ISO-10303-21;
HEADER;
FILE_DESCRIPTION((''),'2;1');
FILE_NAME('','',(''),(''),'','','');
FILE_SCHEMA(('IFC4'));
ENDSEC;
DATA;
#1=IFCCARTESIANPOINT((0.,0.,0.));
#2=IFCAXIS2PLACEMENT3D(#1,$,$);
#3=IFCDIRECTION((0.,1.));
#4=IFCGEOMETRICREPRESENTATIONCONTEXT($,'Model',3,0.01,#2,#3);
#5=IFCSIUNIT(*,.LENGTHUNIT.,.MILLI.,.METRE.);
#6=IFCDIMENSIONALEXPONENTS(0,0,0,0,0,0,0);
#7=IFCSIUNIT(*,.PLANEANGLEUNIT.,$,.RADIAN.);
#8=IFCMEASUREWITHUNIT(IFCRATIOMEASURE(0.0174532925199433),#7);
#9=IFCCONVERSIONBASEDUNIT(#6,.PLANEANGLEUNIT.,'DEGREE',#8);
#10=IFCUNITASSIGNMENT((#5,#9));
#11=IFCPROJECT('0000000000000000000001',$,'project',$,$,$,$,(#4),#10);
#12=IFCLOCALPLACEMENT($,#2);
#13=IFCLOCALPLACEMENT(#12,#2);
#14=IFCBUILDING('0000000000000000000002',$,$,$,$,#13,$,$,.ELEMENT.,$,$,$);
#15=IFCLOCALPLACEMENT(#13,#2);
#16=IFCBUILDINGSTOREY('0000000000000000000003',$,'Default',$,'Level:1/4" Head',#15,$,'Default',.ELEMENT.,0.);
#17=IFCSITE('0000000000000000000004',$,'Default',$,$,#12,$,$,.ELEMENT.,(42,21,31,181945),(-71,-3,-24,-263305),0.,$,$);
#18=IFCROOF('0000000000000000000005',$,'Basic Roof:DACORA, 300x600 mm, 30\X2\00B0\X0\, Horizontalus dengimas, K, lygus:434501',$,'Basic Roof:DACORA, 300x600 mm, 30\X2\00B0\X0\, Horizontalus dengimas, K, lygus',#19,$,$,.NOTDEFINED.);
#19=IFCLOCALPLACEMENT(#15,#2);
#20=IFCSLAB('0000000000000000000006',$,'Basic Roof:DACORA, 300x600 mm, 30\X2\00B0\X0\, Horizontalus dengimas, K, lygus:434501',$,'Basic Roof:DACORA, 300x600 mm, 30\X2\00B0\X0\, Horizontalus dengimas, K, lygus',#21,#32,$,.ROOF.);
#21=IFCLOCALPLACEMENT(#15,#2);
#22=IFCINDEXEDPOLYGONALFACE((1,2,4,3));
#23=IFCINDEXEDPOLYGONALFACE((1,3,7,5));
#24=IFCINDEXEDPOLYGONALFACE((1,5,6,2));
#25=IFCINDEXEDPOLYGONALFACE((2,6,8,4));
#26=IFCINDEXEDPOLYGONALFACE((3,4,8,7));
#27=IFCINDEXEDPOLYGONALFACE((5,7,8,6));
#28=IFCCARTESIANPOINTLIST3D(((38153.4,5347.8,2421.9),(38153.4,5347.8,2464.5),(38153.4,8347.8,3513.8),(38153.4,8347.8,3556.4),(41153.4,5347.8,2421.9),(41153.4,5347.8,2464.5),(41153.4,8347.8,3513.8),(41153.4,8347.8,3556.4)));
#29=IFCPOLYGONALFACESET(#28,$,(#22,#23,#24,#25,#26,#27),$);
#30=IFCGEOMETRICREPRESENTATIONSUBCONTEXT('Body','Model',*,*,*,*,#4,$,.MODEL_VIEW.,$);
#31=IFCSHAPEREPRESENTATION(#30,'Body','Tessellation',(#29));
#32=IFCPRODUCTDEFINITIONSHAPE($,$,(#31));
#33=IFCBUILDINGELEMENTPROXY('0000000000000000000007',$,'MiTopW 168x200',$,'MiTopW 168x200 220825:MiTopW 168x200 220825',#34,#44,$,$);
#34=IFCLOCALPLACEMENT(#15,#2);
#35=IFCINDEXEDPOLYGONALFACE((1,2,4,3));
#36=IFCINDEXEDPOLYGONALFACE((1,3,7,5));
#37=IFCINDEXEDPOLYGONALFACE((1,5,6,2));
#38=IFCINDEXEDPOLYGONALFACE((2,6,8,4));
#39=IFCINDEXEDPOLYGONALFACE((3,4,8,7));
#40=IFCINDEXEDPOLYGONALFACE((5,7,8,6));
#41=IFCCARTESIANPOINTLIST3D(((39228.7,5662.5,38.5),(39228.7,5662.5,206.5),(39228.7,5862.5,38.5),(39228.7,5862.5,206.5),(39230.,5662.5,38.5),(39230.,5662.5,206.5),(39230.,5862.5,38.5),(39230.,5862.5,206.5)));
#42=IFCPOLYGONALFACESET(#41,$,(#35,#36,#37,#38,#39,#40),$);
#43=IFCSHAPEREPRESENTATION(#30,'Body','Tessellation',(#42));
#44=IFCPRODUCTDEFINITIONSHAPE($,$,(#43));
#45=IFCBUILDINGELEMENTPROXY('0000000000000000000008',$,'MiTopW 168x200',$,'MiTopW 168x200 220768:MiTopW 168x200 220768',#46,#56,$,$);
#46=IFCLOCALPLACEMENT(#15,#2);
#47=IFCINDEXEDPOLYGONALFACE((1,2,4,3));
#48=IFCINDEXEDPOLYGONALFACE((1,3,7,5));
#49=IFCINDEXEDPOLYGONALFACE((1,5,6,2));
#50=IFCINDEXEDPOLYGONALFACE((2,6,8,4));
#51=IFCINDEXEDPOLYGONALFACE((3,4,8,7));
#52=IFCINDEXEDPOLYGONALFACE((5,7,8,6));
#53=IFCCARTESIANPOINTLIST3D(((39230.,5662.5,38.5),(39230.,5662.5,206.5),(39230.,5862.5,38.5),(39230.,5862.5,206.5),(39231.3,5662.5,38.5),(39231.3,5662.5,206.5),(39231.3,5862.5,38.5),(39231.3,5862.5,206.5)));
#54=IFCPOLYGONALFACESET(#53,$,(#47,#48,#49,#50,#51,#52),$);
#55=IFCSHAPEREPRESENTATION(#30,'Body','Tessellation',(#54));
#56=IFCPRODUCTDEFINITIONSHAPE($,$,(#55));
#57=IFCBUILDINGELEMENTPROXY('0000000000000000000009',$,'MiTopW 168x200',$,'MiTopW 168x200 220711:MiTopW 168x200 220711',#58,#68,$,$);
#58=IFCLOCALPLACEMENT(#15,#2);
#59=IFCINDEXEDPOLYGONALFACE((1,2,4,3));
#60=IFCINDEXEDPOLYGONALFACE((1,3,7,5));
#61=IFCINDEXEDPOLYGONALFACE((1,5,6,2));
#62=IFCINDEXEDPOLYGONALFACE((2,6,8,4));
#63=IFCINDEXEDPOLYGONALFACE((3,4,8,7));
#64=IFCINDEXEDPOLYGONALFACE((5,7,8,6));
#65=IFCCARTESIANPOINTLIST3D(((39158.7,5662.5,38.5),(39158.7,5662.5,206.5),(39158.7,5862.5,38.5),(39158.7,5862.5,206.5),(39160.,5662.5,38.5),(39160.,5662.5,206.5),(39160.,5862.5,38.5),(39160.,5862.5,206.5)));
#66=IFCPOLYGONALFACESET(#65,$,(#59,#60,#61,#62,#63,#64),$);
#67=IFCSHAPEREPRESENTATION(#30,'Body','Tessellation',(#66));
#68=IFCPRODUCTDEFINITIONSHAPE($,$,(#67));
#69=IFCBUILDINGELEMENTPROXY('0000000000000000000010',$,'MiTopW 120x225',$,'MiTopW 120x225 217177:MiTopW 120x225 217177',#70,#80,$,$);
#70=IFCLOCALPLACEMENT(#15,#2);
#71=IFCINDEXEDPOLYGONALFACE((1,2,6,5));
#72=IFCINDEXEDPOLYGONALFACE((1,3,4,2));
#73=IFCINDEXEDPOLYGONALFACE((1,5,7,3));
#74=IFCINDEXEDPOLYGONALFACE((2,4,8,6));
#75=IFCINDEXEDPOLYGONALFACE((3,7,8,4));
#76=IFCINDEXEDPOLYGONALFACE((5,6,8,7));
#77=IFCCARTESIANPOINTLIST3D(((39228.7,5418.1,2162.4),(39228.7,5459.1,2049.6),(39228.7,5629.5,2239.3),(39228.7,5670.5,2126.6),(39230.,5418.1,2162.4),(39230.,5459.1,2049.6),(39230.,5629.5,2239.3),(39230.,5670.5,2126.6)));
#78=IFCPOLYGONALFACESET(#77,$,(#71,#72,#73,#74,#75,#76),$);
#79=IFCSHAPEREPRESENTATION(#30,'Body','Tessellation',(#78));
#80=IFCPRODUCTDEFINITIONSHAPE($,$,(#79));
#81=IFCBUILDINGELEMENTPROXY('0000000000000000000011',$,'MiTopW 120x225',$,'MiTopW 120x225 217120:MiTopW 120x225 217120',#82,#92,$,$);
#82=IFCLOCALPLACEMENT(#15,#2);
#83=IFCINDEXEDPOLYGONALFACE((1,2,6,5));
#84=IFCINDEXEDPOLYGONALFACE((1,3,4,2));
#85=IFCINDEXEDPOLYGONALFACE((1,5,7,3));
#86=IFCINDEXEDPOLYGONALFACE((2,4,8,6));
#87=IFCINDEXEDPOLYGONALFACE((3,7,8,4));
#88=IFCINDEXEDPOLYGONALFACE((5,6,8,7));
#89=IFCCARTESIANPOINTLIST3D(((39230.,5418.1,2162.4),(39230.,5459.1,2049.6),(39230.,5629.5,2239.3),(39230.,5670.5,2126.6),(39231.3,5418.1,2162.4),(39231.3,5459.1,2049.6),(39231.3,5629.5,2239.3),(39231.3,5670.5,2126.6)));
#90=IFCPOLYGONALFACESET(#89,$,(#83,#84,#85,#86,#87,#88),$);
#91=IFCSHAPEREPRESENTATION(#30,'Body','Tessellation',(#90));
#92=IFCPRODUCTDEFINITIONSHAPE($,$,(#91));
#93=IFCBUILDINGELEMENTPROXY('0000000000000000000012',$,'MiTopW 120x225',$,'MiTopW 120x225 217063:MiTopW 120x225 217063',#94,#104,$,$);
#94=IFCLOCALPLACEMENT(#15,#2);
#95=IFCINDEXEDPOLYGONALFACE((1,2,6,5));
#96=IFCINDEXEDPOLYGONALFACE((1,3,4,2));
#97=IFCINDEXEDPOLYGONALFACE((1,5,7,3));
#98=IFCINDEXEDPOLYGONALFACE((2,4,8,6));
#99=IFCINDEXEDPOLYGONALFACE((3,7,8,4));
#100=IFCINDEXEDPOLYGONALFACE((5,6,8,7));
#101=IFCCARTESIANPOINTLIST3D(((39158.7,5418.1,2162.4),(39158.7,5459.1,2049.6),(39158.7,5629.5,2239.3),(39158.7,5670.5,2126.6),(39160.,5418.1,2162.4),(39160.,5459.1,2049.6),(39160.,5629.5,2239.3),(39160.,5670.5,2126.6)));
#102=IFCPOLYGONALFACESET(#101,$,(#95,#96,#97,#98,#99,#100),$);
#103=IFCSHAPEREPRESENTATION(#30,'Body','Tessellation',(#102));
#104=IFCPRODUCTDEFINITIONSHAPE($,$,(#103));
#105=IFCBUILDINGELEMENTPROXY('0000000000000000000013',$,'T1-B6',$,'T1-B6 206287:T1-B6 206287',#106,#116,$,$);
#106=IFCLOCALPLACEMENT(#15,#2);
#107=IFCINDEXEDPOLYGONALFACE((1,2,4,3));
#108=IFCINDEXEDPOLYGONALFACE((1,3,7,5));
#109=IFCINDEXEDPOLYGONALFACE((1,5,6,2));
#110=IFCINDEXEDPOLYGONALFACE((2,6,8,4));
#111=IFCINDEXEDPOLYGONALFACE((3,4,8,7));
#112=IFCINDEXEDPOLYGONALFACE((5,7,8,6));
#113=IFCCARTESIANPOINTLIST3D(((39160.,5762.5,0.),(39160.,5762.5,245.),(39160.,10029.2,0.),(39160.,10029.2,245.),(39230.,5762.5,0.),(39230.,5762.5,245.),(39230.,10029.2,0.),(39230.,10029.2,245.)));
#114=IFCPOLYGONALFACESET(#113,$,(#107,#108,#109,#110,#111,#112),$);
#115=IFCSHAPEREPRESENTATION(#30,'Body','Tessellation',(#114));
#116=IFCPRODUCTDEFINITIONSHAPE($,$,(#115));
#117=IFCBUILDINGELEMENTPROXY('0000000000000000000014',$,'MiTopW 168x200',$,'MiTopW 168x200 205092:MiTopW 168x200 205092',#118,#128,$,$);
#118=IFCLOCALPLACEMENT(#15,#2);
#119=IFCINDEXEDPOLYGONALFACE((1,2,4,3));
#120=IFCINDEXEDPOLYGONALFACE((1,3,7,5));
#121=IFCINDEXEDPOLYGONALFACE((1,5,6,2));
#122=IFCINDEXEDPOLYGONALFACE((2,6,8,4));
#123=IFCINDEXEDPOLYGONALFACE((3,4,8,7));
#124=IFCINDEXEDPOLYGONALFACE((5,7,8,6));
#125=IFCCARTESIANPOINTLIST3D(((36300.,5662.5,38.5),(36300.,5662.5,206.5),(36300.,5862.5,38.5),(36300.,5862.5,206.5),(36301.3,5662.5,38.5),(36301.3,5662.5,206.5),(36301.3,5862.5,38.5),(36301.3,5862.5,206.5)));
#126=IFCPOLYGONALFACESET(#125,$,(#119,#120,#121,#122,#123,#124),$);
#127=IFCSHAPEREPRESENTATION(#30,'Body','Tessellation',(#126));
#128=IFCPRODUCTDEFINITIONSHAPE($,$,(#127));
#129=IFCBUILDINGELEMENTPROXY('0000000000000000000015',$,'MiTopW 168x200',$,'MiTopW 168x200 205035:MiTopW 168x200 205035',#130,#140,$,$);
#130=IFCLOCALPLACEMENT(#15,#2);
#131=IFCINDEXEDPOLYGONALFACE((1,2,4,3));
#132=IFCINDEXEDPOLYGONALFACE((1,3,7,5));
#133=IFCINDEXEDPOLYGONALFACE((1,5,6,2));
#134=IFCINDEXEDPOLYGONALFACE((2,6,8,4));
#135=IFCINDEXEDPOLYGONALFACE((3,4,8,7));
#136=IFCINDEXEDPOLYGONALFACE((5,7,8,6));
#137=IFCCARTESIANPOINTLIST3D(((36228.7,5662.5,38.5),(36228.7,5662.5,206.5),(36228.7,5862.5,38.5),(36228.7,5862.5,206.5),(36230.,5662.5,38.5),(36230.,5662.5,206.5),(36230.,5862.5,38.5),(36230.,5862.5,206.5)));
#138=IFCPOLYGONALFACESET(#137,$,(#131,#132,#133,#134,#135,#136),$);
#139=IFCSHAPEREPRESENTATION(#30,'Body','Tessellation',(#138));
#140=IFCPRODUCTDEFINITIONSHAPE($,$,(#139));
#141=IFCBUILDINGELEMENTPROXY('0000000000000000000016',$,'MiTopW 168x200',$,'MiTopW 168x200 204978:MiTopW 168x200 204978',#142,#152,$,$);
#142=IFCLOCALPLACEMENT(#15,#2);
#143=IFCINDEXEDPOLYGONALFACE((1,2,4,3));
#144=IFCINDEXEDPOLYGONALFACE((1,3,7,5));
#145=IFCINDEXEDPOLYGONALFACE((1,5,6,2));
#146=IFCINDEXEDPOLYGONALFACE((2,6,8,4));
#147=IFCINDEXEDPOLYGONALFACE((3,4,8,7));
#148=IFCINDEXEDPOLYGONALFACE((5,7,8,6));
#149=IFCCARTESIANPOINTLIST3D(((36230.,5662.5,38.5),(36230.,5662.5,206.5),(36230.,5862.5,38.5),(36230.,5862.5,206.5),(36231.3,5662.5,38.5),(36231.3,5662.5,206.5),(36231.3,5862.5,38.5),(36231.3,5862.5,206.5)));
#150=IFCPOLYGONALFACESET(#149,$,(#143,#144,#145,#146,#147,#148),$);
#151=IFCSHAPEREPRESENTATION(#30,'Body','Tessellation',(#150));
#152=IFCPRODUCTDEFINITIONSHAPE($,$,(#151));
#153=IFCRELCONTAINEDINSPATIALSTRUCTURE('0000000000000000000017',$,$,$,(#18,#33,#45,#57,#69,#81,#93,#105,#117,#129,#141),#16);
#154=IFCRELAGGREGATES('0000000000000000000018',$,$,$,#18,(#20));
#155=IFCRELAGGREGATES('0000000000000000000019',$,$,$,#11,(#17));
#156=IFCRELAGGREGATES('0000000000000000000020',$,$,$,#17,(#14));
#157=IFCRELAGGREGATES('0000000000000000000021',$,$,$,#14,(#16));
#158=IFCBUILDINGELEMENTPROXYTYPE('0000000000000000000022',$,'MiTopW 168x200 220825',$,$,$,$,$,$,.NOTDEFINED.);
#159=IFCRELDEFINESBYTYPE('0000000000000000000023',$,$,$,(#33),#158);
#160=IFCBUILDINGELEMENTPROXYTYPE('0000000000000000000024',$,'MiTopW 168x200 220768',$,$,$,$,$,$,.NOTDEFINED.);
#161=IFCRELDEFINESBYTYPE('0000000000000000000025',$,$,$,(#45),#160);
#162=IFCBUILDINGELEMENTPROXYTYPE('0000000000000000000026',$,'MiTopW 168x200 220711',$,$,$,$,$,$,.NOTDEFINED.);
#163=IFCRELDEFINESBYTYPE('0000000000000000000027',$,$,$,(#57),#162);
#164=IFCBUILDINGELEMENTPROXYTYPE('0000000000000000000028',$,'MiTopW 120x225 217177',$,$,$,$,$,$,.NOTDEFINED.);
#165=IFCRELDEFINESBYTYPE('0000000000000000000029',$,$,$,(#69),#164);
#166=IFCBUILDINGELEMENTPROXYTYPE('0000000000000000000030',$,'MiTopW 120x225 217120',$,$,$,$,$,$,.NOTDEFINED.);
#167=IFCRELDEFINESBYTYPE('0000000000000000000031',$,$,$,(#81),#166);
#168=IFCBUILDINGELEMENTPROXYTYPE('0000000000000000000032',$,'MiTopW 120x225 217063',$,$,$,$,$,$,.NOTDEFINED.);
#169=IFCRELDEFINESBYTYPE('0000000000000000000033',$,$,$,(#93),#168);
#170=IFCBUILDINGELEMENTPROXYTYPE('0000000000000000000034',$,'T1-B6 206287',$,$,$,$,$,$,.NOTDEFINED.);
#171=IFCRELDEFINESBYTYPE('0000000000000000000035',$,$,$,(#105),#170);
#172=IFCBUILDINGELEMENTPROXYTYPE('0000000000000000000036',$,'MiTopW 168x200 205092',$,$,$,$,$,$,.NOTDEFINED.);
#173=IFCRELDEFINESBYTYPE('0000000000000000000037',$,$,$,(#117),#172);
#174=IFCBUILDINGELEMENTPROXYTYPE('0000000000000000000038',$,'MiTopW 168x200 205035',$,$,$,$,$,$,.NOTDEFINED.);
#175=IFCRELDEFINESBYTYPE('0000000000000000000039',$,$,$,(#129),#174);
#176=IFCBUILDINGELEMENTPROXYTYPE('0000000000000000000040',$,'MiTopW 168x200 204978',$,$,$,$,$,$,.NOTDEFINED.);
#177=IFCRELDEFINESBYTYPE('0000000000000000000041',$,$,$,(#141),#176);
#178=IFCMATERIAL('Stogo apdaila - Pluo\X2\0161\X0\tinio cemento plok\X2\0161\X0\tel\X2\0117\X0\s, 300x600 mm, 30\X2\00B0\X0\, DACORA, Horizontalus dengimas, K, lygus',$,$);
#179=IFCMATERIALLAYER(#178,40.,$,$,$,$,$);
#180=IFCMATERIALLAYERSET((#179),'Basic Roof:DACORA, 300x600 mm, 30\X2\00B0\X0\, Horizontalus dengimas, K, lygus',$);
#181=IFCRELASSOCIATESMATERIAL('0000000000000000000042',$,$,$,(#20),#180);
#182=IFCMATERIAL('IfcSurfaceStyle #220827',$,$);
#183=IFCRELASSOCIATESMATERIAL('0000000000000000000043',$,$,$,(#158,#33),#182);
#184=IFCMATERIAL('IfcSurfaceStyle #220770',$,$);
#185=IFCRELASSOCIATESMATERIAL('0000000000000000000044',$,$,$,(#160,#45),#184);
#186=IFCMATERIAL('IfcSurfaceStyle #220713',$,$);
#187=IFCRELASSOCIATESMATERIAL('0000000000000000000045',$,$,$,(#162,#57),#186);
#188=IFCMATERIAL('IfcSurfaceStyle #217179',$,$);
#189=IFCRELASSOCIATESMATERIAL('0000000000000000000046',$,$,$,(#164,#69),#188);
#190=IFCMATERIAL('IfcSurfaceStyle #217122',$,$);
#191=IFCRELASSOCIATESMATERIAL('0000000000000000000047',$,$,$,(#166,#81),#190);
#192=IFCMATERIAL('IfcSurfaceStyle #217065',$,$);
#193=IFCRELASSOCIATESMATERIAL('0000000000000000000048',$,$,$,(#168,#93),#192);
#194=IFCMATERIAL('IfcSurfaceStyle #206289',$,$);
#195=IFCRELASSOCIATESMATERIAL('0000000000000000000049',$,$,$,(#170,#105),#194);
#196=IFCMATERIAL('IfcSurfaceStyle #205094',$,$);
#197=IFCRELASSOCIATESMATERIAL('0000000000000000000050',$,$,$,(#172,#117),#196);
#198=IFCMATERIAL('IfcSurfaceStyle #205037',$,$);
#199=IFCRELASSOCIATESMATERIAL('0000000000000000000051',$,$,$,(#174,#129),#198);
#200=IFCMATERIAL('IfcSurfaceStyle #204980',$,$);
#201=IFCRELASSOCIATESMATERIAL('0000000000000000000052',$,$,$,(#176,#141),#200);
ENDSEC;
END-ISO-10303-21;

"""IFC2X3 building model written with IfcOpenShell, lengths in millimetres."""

from ifc_helpers import new_model, entity, si_unit, converted_unit, direction, frame, frame_2d, origin, origin_2d_with_axis, place, context, subcontext, project, spatial, polyline, rectangle, outline, extrude, source, transform, mapped, material, layer, layer_set, type_object, type_shapes, element, aggregate, save


model = new_model("IFC2X3")

# Units and contexts
model_context = context("Model", 3, precision=0.01, world=origin(), true_north=direction((0.0, 1.0)))
body_context = subcontext(model_context, "Body", "Model", "MODEL_VIEW")
ifc_project = project(units=[si_unit("LENGTHUNIT", "METRE", prefix="MILLI"), converted_unit("PLANEANGLEUNIT", "DEGREE", entity("IfcRatioMeasure", 0.0174532925199433), si_unit("PLANEANGLEUNIT", "RADIAN"), dimensions=[0, 0, 0, 0, 0, 0, 0])], contexts=[model_context])

# Site, building, storey
site_placement = place(None, origin())
site = spatial("IfcSite", under=ifc_project, at=site_placement, Name="Default", CompositionType="ELEMENT", RefLatitude=(42, 21, 31, 181945), RefLongitude=(-71, -3, -24, -263305), RefElevation=0.0)
building_placement = place(site_placement, origin())
building = spatial("IfcBuilding", under=site, at=building_placement, CompositionType="ELEMENT")
storey_placement = place(building_placement, origin())
storey = spatial("IfcBuildingStorey", under=building, at=storey_placement, Name="Default", ObjectType="Level:1/4\" Head", LongName="Default", CompositionType="ELEMENT", Elevation=0.0)

# Roof, slab
roof_placement = place(storey_placement, frame((38153.4, 5347.8, 2421.9)))
roof = element("IfcRoof", 1, at=roof_placement, inside=storey, Name="Basic Roof:DACORA, 300x600 mm, 30°, Horizontalus dengimas, K, lygus:434501", ObjectType="Basic Roof:DACORA, 300x600 mm, 30°, Horizontalus dengimas, K, lygus", ShapeType="NOTDEFINED")
ifc_material_1 = material(Name="Stogo apdaila - Pluoštinio cemento plokštelės, 300x600 mm, 30°, DACORA, Horizontalus dengimas, K, lygus")
ifc_layer = layer(ifc_material_1, 40.0)
ifc_layer_set = layer_set([ifc_layer], Name="Basic Roof:DACORA, 300x600 mm, 30°, Horizontalus dengimas, K, lygus")
slab_placement = place(roof_placement, origin())
slab = element("IfcSlab", 2, at=slab_placement, material=ifc_layer_set, Name="Basic Roof:DACORA, 300x600 mm, 30°, Horizontalus dengimas, K, lygus:434501", ObjectType="Basic Roof:DACORA, 300x600 mm, 30°, Horizontalus dengimas, K, lygus", PredefinedType="ROOF", context=body_context, shape_type="SweptSolid", body=[
    extrude(rectangle(XDim=3192.5, YDim=3000.0, at=frame_2d((0.0, 0.0), x_axis=(0.0, -1.0))), frame((1500.0, 1500.0, 546.0), z_axis=(0.0, -0.34202, 0.939693), x_axis=(1.0, 0.0, 0.0)), (0.0, 0.34202, 0.939693), 42.6),
])
aggregate(roof, [slab])

# Building element proxies
ifc_material_2 = material(Name="IfcSurfaceStyle #220827")
building_element_proxy_type_1 = type_object("IfcBuildingElementProxyType", Name="MiTopW 168x200 220825", PredefinedType="NOTDEFINED", material=ifc_material_2)
shared_shape_1 = source(origin(), body_context, "Body", "SweptSolid", [
    extrude(rectangle(XDim=200.0, YDim=168.0, at=origin_2d_with_axis()), frame((100.0, 84.0, 0.0), z_axis=(0.0, 0.0, 1.0), x_axis=(-1.0, 0.0, 0.0)), (0.0, 0.0, 1.0), 1.3),
])
type_shapes(building_element_proxy_type_1, [shared_shape_1])
proxy_1_placement = place(building_placement, frame((39230.0, 5662.5, 206.5), z_axis=(-1.0, 0.0, 0.0), x_axis=(0.0, 1.0, 0.0)))
element("IfcBuildingElementProxy", 3, at=proxy_1_placement, inside=storey, type_object=building_element_proxy_type_1, material=ifc_material_2, Name="MiTopW 168x200", ObjectType="MiTopW 168x200 220825:MiTopW 168x200 220825", context=body_context, shape_type="MappedRepresentation", body=[
    mapped(shared_shape_1, transform((0.0, 0.0, 0.0), scale=1.0)),
])
ifc_material_3 = material(Name="IfcSurfaceStyle #220770")
building_element_proxy_type_2 = type_object("IfcBuildingElementProxyType", Name="MiTopW 168x200 220768", PredefinedType="NOTDEFINED", material=ifc_material_3)
shared_shape_2 = source(origin(), body_context, "Body", "SweptSolid", [
    extrude(rectangle(XDim=200.0, YDim=168.0, at=origin_2d_with_axis()), frame((100.0, 84.0, 0.0), z_axis=(0.0, 0.0, 1.0), x_axis=(-1.0, 0.0, 0.0)), (0.0, 0.0, 1.0), 1.3),
])
type_shapes(building_element_proxy_type_2, [shared_shape_2])
proxy_2_placement = place(building_placement, frame((39231.3, 5662.5, 206.5), z_axis=(-1.0, 0.0, 0.0), x_axis=(0.0, 1.0, 0.0)))
element("IfcBuildingElementProxy", 4, at=proxy_2_placement, inside=storey, type_object=building_element_proxy_type_2, material=ifc_material_3, Name="MiTopW 168x200", ObjectType="MiTopW 168x200 220768:MiTopW 168x200 220768", context=body_context, shape_type="MappedRepresentation", body=[
    mapped(shared_shape_2, transform((0.0, 0.0, 0.0), scale=1.0)),
])
ifc_material_4 = material(Name="IfcSurfaceStyle #220713")
building_element_proxy_type_3 = type_object("IfcBuildingElementProxyType", Name="MiTopW 168x200 220711", PredefinedType="NOTDEFINED", material=ifc_material_4)
shared_shape_3 = source(origin(), body_context, "Body", "SweptSolid", [
    extrude(rectangle(XDim=200.0, YDim=168.0, at=origin_2d_with_axis()), frame((100.0, 84.0, 0.0), z_axis=(0.0, 0.0, 1.0), x_axis=(-1.0, 0.0, 0.0)), (0.0, 0.0, 1.0), 1.3),
])
type_shapes(building_element_proxy_type_3, [shared_shape_3])
proxy_3_placement = place(building_placement, frame((39160.0, 5662.5, 206.5), z_axis=(-1.0, 0.0, 0.0), x_axis=(0.0, 1.0, 0.0)))
element("IfcBuildingElementProxy", 5, at=proxy_3_placement, inside=storey, type_object=building_element_proxy_type_3, material=ifc_material_4, Name="MiTopW 168x200", ObjectType="MiTopW 168x200 220711:MiTopW 168x200 220711", context=body_context, shape_type="MappedRepresentation", body=[
    mapped(shared_shape_3, transform((0.0, 0.0, 0.0), scale=1.0)),
])
ifc_material_5 = material(Name="IfcSurfaceStyle #217179")
building_element_proxy_type_4 = type_object("IfcBuildingElementProxyType", Name="MiTopW 120x225 217177", PredefinedType="NOTDEFINED", material=ifc_material_5)
shared_shape_4 = source(origin(), body_context, "Body", "SweptSolid", [
    extrude(outline(polyline([(-112.5, -60.0), (112.5, -60.0), (112.5, 60.0), (-112.5, 60.0), (-112.5, -60.0)])), frame((112.5, 60.0, 0.0), z_axis=(0.0, 0.0, 1.0), x_axis=(-1.0, 0.0, 0.0)), (0.0, 0.0, 1.0), 1.3),
])
type_shapes(building_element_proxy_type_4, [shared_shape_4])
proxy_4_placement = place(building_placement, frame((39230.0, 5418.1, 2162.4), z_axis=(-1.0, 0.0, 0.0), x_axis=(0.0, 0.939693, 0.34202)))
element("IfcBuildingElementProxy", 6, at=proxy_4_placement, inside=storey, type_object=building_element_proxy_type_4, material=ifc_material_5, Name="MiTopW 120x225", ObjectType="MiTopW 120x225 217177:MiTopW 120x225 217177", context=body_context, shape_type="MappedRepresentation", body=[
    mapped(shared_shape_4, transform((0.0, 0.0, 0.0), scale=1.0)),
])
ifc_material_6 = material(Name="IfcSurfaceStyle #217122")
building_element_proxy_type_5 = type_object("IfcBuildingElementProxyType", Name="MiTopW 120x225 217120", PredefinedType="NOTDEFINED", material=ifc_material_6)
shared_shape_5 = source(origin(), body_context, "Body", "SweptSolid", [
    extrude(outline(polyline([(-112.5, -60.0), (112.5, -60.0), (112.5, 60.0), (-112.5, 60.0), (-112.5, -60.0)])), frame((112.5, 60.0, 0.0), z_axis=(0.0, 0.0, 1.0), x_axis=(-1.0, 0.0, 0.0)), (0.0, 0.0, 1.0), 1.3),
])
type_shapes(building_element_proxy_type_5, [shared_shape_5])
proxy_5_placement = place(building_placement, frame((39231.3, 5418.1, 2162.4), z_axis=(-1.0, 0.0, 0.0), x_axis=(0.0, 0.939693, 0.34202)))
element("IfcBuildingElementProxy", 7, at=proxy_5_placement, inside=storey, type_object=building_element_proxy_type_5, material=ifc_material_6, Name="MiTopW 120x225", ObjectType="MiTopW 120x225 217120:MiTopW 120x225 217120", context=body_context, shape_type="MappedRepresentation", body=[
    mapped(shared_shape_5, transform((0.0, 0.0, 0.0), scale=1.0)),
])
ifc_material_7 = material(Name="IfcSurfaceStyle #217065")
building_element_proxy_type_6 = type_object("IfcBuildingElementProxyType", Name="MiTopW 120x225 217063", PredefinedType="NOTDEFINED", material=ifc_material_7)
shared_shape_6 = source(origin(), body_context, "Body", "SweptSolid", [
    extrude(outline(polyline([(-112.5, -60.0), (112.5, -60.0), (112.5, 60.0), (-112.5, 60.0), (-112.5, -60.0)])), frame((112.5, 60.0, 0.0), z_axis=(0.0, 0.0, 1.0), x_axis=(-1.0, 0.0, 0.0)), (0.0, 0.0, 1.0), 1.3),
])
type_shapes(building_element_proxy_type_6, [shared_shape_6])
proxy_6_placement = place(building_placement, frame((39160.0, 5418.1, 2162.4), z_axis=(-1.0, 0.0, 0.0), x_axis=(0.0, 0.939693, 0.34202)))
element("IfcBuildingElementProxy", 8, at=proxy_6_placement, inside=storey, type_object=building_element_proxy_type_6, material=ifc_material_7, Name="MiTopW 120x225", ObjectType="MiTopW 120x225 217063:MiTopW 120x225 217063", context=body_context, shape_type="MappedRepresentation", body=[
    mapped(shared_shape_6, transform((0.0, 0.0, 0.0), scale=1.0)),
])
ifc_material_8 = material(Name="IfcSurfaceStyle #206289")
building_element_proxy_type_7 = type_object("IfcBuildingElementProxyType", Name="T1-B6 206287", PredefinedType="NOTDEFINED", material=ifc_material_8)
shared_shape_7 = source(origin(), body_context, "Body", "SweptSolid", [
    extrude(rectangle(XDim=4266.8, YDim=245.0, at=origin_2d_with_axis()), frame((2133.4, 122.5, 0.0), z_axis=(0.0, 0.0, 1.0), x_axis=(-1.0, 0.0, 0.0)), (0.0, 0.0, 1.0), 70.0),
])
type_shapes(building_element_proxy_type_7, [shared_shape_7])
proxy_7_placement = place(building_placement, frame((39230.0, 5762.5, 245.0), z_axis=(-1.0, 0.0, 0.0), x_axis=(0.0, 1.0, 0.0)))
element("IfcBuildingElementProxy", 9, at=proxy_7_placement, inside=storey, type_object=building_element_proxy_type_7, material=ifc_material_8, Name="T1-B6", ObjectType="T1-B6 206287:T1-B6 206287", context=body_context, shape_type="MappedRepresentation", body=[
    mapped(shared_shape_7, transform((0.0, 0.0, 0.0), scale=1.0)),
])
ifc_material_9 = material(Name="IfcSurfaceStyle #205094")
building_element_proxy_type_8 = type_object("IfcBuildingElementProxyType", Name="MiTopW 168x200 205092", PredefinedType="NOTDEFINED", material=ifc_material_9)
shared_shape_8 = source(origin(), body_context, "Body", "SweptSolid", [
    extrude(rectangle(XDim=200.0, YDim=168.0, at=origin_2d_with_axis()), frame((100.0, 84.0, 0.0), z_axis=(0.0, 0.0, 1.0), x_axis=(-1.0, 0.0, 0.0)), (0.0, 0.0, 1.0), 1.3),
])
type_shapes(building_element_proxy_type_8, [shared_shape_8])
proxy_8_placement = place(building_placement, frame((36301.3, 5662.5, 206.5), z_axis=(-1.0, 0.0, 0.0), x_axis=(0.0, 1.0, 0.0)))
element("IfcBuildingElementProxy", 10, at=proxy_8_placement, inside=storey, type_object=building_element_proxy_type_8, material=ifc_material_9, Name="MiTopW 168x200", ObjectType="MiTopW 168x200 205092:MiTopW 168x200 205092", context=body_context, shape_type="MappedRepresentation", body=[
    mapped(shared_shape_8, transform((0.0, 0.0, 0.0), scale=1.0)),
])
ifc_material_10 = material(Name="IfcSurfaceStyle #205037")
building_element_proxy_type_9 = type_object("IfcBuildingElementProxyType", Name="MiTopW 168x200 205035", PredefinedType="NOTDEFINED", material=ifc_material_10)
shared_shape_9 = source(origin(), body_context, "Body", "SweptSolid", [
    extrude(rectangle(XDim=200.0, YDim=168.0, at=origin_2d_with_axis()), frame((100.0, 84.0, 0.0), z_axis=(0.0, 0.0, 1.0), x_axis=(-1.0, 0.0, 0.0)), (0.0, 0.0, 1.0), 1.3),
])
type_shapes(building_element_proxy_type_9, [shared_shape_9])
proxy_9_placement = place(building_placement, frame((36230.0, 5662.5, 206.5), z_axis=(-1.0, 0.0, 0.0), x_axis=(0.0, 1.0, 0.0)))
element("IfcBuildingElementProxy", 11, at=proxy_9_placement, inside=storey, type_object=building_element_proxy_type_9, material=ifc_material_10, Name="MiTopW 168x200", ObjectType="MiTopW 168x200 205035:MiTopW 168x200 205035", context=body_context, shape_type="MappedRepresentation", body=[
    mapped(shared_shape_9, transform((0.0, 0.0, 0.0), scale=1.0)),
])
ifc_material_11 = material(Name="IfcSurfaceStyle #204980")
building_element_proxy_type_10 = type_object("IfcBuildingElementProxyType", Name="MiTopW 168x200 204978", PredefinedType="NOTDEFINED", material=ifc_material_11)
shared_shape_10 = source(origin(), body_context, "Body", "SweptSolid", [
    extrude(rectangle(XDim=200.0, YDim=168.0, at=origin_2d_with_axis()), frame((100.0, 84.0, 0.0), z_axis=(0.0, 0.0, 1.0), x_axis=(-1.0, 0.0, 0.0)), (0.0, 0.0, 1.0), 1.3),
])
type_shapes(building_element_proxy_type_10, [shared_shape_10])
proxy_10_placement = place(building_placement, frame((36231.3, 5662.5, 206.5), z_axis=(-1.0, 0.0, 0.0), x_axis=(0.0, 1.0, 0.0)))
element("IfcBuildingElementProxy", 12, at=proxy_10_placement, inside=storey, type_object=building_element_proxy_type_10, material=ifc_material_11, Name="MiTopW 168x200", ObjectType="MiTopW 168x200 204978:MiTopW 168x200 204978", context=body_context, shape_type="MappedRepresentation", body=[
    mapped(shared_shape_10, transform((0.0, 0.0, 0.0), scale=1.0)),
])

save(model, "model.ifc")
